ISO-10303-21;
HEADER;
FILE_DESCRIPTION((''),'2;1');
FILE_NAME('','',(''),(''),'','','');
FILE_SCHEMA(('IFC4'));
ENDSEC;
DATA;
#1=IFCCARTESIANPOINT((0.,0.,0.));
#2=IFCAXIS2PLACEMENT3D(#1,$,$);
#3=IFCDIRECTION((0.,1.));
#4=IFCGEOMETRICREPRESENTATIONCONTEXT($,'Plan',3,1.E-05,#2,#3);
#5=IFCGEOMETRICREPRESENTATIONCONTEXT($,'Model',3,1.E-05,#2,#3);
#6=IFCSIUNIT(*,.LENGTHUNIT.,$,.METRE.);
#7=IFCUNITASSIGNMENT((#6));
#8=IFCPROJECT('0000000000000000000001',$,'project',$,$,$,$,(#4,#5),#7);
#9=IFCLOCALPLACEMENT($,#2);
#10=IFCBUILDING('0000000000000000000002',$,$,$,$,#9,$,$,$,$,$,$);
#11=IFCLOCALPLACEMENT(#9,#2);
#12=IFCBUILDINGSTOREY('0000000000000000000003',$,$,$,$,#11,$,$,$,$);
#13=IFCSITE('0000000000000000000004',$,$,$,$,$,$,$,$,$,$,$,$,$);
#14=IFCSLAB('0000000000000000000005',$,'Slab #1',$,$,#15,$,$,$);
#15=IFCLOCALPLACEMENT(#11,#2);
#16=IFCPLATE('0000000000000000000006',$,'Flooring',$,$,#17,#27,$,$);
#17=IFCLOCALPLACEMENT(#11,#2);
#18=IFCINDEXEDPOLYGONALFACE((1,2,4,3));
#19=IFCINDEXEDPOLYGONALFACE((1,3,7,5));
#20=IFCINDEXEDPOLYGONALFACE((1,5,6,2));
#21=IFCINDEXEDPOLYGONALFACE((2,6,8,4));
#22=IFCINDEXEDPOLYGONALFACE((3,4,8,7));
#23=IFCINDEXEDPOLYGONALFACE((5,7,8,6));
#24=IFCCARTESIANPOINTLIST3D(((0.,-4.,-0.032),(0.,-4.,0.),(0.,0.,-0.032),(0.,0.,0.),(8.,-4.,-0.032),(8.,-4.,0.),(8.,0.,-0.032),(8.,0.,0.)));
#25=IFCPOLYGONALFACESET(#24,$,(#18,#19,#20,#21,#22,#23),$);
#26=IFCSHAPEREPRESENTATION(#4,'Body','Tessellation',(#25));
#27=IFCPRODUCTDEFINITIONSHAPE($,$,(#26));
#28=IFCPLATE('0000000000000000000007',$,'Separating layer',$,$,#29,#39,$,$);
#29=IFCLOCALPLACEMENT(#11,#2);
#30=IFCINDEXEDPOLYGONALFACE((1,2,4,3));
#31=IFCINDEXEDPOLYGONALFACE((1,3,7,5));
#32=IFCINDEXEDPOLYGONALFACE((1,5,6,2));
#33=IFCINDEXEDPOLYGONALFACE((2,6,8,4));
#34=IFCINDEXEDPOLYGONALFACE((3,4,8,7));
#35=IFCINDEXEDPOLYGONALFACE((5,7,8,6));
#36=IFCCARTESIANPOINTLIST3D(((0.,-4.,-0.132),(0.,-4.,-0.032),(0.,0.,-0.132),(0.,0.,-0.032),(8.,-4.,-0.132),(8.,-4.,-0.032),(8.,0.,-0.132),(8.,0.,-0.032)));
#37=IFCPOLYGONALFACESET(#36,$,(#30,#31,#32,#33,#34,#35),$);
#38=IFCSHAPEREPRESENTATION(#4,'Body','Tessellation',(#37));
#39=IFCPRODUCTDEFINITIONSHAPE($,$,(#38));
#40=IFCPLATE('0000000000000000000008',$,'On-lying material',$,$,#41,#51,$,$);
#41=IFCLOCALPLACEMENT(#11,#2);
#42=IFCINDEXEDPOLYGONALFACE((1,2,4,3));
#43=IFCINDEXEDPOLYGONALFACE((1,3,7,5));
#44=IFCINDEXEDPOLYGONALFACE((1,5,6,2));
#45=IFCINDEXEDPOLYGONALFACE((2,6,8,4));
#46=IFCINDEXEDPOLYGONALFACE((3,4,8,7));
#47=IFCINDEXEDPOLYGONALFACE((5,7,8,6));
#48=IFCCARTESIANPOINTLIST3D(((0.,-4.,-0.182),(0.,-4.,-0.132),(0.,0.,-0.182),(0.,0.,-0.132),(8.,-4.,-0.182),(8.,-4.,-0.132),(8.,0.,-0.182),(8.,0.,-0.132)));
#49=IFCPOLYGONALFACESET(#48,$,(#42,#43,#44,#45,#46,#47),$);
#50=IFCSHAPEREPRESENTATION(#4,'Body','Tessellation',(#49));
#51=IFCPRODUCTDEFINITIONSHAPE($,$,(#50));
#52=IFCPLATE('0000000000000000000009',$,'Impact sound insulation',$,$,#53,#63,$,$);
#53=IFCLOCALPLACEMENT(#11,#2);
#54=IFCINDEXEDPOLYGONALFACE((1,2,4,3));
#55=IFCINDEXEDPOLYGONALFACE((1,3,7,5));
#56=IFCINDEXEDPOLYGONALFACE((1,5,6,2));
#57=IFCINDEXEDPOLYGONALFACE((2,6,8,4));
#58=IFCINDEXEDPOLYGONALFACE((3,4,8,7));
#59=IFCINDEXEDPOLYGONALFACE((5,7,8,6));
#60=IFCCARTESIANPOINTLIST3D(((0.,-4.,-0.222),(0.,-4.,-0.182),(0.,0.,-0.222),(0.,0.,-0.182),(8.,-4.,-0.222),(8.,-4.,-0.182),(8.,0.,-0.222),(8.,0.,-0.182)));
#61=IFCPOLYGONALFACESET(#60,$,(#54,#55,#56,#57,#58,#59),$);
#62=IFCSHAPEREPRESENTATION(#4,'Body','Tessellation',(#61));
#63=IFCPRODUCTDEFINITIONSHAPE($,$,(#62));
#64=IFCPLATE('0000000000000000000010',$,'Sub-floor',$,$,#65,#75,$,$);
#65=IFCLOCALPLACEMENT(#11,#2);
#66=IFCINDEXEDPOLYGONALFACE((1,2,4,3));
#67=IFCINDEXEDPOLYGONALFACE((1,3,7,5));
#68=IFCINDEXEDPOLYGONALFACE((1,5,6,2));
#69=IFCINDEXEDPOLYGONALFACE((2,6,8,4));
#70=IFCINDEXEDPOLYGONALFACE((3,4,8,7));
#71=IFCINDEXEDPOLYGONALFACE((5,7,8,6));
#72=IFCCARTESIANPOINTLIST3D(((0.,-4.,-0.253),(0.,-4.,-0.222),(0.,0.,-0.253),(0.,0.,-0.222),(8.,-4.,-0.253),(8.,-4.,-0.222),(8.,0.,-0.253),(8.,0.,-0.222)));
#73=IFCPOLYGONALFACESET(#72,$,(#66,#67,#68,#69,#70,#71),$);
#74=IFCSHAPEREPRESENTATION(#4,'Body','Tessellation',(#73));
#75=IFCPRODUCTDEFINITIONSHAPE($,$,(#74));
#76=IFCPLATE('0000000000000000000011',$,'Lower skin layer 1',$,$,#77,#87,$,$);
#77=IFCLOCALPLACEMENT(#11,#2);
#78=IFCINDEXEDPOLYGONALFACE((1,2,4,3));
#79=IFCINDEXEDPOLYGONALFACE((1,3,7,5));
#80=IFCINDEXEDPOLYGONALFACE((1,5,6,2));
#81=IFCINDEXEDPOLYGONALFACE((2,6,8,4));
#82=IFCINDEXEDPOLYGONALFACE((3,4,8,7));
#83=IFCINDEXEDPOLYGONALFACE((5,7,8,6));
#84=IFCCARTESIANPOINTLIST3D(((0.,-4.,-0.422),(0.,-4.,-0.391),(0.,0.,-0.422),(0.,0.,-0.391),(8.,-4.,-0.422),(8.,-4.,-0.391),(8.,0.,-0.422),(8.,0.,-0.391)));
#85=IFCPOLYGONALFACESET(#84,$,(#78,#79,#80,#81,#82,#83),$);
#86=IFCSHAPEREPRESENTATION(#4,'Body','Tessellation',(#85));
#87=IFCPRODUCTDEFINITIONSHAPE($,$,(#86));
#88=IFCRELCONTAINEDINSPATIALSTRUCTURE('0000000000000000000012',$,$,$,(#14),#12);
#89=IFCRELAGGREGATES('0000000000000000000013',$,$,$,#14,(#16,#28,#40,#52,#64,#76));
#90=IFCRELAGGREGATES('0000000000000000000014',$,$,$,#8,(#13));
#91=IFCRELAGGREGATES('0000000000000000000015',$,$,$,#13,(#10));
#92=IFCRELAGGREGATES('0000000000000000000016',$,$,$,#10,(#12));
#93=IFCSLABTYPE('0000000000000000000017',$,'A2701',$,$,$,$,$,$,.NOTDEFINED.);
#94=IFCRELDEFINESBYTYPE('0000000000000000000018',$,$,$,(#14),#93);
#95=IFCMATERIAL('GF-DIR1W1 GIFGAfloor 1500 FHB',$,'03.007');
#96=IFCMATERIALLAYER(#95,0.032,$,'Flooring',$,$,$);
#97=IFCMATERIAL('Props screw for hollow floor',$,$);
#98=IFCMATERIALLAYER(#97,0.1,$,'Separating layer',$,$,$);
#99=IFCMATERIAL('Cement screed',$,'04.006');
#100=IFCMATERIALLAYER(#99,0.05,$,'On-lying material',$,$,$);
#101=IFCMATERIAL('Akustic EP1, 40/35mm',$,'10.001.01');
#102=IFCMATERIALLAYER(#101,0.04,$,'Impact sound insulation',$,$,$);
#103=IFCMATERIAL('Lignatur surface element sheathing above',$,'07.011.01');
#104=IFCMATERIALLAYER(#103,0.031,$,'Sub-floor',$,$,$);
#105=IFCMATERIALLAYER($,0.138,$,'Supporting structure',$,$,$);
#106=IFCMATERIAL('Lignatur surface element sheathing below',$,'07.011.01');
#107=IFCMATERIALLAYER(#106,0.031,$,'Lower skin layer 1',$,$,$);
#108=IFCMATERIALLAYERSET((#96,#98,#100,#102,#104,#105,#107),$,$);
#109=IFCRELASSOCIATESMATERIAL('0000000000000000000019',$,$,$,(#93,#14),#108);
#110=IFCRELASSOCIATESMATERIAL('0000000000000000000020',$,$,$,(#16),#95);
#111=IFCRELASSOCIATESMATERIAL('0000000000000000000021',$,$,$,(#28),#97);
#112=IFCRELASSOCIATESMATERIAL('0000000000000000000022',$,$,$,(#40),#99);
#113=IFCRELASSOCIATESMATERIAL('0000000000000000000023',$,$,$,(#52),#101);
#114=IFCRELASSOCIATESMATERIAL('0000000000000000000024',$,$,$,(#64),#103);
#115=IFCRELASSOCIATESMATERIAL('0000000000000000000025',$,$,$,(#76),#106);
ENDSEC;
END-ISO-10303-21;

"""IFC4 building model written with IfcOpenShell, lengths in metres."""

from ifc_helpers import new_model, si_unit, direction, frame, frame_2d, origin, origin_with_axes, place, context, project, spatial, rectangle, extrude, material, layer, layer_set, type_object, element, aggregate, save


model = new_model("IFC4")

# Units and contexts
plan_context = context("Plan", 3, precision=1e-05, world=origin(), true_north=direction((0.0, 1.0)))
model_context = context("Model", 3, precision=1e-05, world=origin(), true_north=direction((0.0, 1.0)))
ifc_project = project(units=[si_unit("LENGTHUNIT", "METRE")], contexts=[plan_context, model_context])

# Site, building, storey
site = spatial("IfcSite", under=ifc_project)
building_placement = place(None, origin())
building = spatial("IfcBuilding", under=site, at=building_placement)
storey_placement = place(building_placement, origin())
storey = spatial("IfcBuildingStorey", under=building, at=storey_placement)

# Slab, plates
ifc_material_1 = material(Name="GF-DIR1W1 GIFGAfloor 1500 FHB", Category="03.007")
ifc_layer_1 = layer(ifc_material_1, 0.032, Name="Flooring")
ifc_material_2 = material(Name="Props screw for hollow floor")
ifc_layer_2 = layer(ifc_material_2, 0.1, Name="Separating layer")
ifc_material_3 = material(Name="Cement screed", Category="04.006")
ifc_layer_3 = layer(ifc_material_3, 0.05, Name="On-lying material")
ifc_material_4 = material(Name="Akustic EP1, 40/35mm", Category="10.001.01")
ifc_layer_4 = layer(ifc_material_4, 0.04, Name="Impact sound insulation")
ifc_material_5 = material(Name="Lignatur surface element sheathing above", Category="07.011.01")
ifc_layer_5 = layer(ifc_material_5, 0.031, Name="Sub-floor")
ifc_layer_6 = layer(None, 0.138, Name="Supporting structure")
ifc_material_6 = material(Name="Lignatur surface element sheathing below", Category="07.011.01")
ifc_layer_7 = layer(ifc_material_6, 0.031, Name="Lower skin layer 1")
ifc_layer_set = layer_set([ifc_layer_1, ifc_layer_2, ifc_layer_3, ifc_layer_4, ifc_layer_5, ifc_layer_6, ifc_layer_7])
slab_type = type_object("IfcSlabType", Name="A2701", PredefinedType="NOTDEFINED", material=ifc_layer_set)
slab_placement = place(None, frame((0.0, 0.0, 0.0), z_axis=(0.0, 0.0, -1.0), x_axis=(1.0, 0.0, 0.0)))
slab = element("IfcSlab", 1, at=slab_placement, inside=storey, type_object=slab_type, material=ifc_layer_set, Name="Slab #1")
plate_1_placement = place(slab_placement, origin())
plate_1 = element("IfcPlate", 2, at=plate_1_placement, material=ifc_material_1, Name="Flooring", context=plan_context, shape_type="SweptSolid", body=[
    extrude(rectangle(XDim=8.0, YDim=4.0, at=frame_2d((4.0, 2.0), x_axis=(1.0, 0.0))), origin_with_axes(), (0.0, 0.0, 1.0), 0.032),
])
plate_2_placement = place(slab_placement, origin())
plate_2 = element("IfcPlate", 3, at=plate_2_placement, material=ifc_material_2, Name="Separating layer", context=plan_context, shape_type="SweptSolid", body=[
    extrude(rectangle(XDim=8.0, YDim=4.0, at=frame_2d((4.0, 2.0), x_axis=(1.0, 0.0))), frame((0.0, 0.0, 0.032), z_axis=(0.0, 0.0, 1.0), x_axis=(1.0, 0.0, 0.0)), (0.0, 0.0, 1.0), 0.1),
])
plate_3_placement = place(slab_placement, origin())
plate_3 = element("IfcPlate", 4, at=plate_3_placement, material=ifc_material_3, Name="On-lying material", context=plan_context, shape_type="SweptSolid", body=[
    extrude(rectangle(XDim=8.0, YDim=4.0, at=frame_2d((4.0, 2.0), x_axis=(1.0, 0.0))), frame((0.0, 0.0, 0.132), z_axis=(0.0, 0.0, 1.0), x_axis=(1.0, 0.0, 0.0)), (0.0, 0.0, 1.0), 0.05),
])
plate_4_placement = place(slab_placement, origin())
plate_4 = element("IfcPlate", 5, at=plate_4_placement, material=ifc_material_4, Name="Impact sound insulation", context=plan_context, shape_type="SweptSolid", body=[
    extrude(rectangle(XDim=8.0, YDim=4.0, at=frame_2d((4.0, 2.0), x_axis=(1.0, 0.0))), frame((0.0, 0.0, 0.182), z_axis=(0.0, 0.0, 1.0), x_axis=(1.0, 0.0, 0.0)), (0.0, 0.0, 1.0), 0.04),
])
plate_5_placement = place(slab_placement, origin())
plate_5 = element("IfcPlate", 6, at=plate_5_placement, material=ifc_material_5, Name="Sub-floor", context=plan_context, shape_type="SweptSolid", body=[
    extrude(rectangle(XDim=8.0, YDim=4.0, at=frame_2d((4.0, 2.0), x_axis=(1.0, 0.0))), frame((0.0, 0.0, 0.222), z_axis=(0.0, 0.0, 1.0), x_axis=(1.0, 0.0, 0.0)), (0.0, 0.0, 1.0), 0.031),
])
plate_6_placement = place(slab_placement, origin())
plate_6 = element("IfcPlate", 7, at=plate_6_placement, material=ifc_material_6, Name="Lower skin layer 1", context=plan_context, shape_type="SweptSolid", body=[
    extrude(rectangle(XDim=8.0, YDim=4.0, at=frame_2d((4.0, 2.0), x_axis=(1.0, 0.0))), frame((0.0, 0.0, 0.391), z_axis=(0.0, 0.0, 1.0), x_axis=(1.0, 0.0, 0.0)), (0.0, 0.0, 1.0), 0.031),
])
aggregate(slab, [plate_1, plate_2, plate_3, plate_4, plate_5, plate_6])

save(model, "model.ifc")
